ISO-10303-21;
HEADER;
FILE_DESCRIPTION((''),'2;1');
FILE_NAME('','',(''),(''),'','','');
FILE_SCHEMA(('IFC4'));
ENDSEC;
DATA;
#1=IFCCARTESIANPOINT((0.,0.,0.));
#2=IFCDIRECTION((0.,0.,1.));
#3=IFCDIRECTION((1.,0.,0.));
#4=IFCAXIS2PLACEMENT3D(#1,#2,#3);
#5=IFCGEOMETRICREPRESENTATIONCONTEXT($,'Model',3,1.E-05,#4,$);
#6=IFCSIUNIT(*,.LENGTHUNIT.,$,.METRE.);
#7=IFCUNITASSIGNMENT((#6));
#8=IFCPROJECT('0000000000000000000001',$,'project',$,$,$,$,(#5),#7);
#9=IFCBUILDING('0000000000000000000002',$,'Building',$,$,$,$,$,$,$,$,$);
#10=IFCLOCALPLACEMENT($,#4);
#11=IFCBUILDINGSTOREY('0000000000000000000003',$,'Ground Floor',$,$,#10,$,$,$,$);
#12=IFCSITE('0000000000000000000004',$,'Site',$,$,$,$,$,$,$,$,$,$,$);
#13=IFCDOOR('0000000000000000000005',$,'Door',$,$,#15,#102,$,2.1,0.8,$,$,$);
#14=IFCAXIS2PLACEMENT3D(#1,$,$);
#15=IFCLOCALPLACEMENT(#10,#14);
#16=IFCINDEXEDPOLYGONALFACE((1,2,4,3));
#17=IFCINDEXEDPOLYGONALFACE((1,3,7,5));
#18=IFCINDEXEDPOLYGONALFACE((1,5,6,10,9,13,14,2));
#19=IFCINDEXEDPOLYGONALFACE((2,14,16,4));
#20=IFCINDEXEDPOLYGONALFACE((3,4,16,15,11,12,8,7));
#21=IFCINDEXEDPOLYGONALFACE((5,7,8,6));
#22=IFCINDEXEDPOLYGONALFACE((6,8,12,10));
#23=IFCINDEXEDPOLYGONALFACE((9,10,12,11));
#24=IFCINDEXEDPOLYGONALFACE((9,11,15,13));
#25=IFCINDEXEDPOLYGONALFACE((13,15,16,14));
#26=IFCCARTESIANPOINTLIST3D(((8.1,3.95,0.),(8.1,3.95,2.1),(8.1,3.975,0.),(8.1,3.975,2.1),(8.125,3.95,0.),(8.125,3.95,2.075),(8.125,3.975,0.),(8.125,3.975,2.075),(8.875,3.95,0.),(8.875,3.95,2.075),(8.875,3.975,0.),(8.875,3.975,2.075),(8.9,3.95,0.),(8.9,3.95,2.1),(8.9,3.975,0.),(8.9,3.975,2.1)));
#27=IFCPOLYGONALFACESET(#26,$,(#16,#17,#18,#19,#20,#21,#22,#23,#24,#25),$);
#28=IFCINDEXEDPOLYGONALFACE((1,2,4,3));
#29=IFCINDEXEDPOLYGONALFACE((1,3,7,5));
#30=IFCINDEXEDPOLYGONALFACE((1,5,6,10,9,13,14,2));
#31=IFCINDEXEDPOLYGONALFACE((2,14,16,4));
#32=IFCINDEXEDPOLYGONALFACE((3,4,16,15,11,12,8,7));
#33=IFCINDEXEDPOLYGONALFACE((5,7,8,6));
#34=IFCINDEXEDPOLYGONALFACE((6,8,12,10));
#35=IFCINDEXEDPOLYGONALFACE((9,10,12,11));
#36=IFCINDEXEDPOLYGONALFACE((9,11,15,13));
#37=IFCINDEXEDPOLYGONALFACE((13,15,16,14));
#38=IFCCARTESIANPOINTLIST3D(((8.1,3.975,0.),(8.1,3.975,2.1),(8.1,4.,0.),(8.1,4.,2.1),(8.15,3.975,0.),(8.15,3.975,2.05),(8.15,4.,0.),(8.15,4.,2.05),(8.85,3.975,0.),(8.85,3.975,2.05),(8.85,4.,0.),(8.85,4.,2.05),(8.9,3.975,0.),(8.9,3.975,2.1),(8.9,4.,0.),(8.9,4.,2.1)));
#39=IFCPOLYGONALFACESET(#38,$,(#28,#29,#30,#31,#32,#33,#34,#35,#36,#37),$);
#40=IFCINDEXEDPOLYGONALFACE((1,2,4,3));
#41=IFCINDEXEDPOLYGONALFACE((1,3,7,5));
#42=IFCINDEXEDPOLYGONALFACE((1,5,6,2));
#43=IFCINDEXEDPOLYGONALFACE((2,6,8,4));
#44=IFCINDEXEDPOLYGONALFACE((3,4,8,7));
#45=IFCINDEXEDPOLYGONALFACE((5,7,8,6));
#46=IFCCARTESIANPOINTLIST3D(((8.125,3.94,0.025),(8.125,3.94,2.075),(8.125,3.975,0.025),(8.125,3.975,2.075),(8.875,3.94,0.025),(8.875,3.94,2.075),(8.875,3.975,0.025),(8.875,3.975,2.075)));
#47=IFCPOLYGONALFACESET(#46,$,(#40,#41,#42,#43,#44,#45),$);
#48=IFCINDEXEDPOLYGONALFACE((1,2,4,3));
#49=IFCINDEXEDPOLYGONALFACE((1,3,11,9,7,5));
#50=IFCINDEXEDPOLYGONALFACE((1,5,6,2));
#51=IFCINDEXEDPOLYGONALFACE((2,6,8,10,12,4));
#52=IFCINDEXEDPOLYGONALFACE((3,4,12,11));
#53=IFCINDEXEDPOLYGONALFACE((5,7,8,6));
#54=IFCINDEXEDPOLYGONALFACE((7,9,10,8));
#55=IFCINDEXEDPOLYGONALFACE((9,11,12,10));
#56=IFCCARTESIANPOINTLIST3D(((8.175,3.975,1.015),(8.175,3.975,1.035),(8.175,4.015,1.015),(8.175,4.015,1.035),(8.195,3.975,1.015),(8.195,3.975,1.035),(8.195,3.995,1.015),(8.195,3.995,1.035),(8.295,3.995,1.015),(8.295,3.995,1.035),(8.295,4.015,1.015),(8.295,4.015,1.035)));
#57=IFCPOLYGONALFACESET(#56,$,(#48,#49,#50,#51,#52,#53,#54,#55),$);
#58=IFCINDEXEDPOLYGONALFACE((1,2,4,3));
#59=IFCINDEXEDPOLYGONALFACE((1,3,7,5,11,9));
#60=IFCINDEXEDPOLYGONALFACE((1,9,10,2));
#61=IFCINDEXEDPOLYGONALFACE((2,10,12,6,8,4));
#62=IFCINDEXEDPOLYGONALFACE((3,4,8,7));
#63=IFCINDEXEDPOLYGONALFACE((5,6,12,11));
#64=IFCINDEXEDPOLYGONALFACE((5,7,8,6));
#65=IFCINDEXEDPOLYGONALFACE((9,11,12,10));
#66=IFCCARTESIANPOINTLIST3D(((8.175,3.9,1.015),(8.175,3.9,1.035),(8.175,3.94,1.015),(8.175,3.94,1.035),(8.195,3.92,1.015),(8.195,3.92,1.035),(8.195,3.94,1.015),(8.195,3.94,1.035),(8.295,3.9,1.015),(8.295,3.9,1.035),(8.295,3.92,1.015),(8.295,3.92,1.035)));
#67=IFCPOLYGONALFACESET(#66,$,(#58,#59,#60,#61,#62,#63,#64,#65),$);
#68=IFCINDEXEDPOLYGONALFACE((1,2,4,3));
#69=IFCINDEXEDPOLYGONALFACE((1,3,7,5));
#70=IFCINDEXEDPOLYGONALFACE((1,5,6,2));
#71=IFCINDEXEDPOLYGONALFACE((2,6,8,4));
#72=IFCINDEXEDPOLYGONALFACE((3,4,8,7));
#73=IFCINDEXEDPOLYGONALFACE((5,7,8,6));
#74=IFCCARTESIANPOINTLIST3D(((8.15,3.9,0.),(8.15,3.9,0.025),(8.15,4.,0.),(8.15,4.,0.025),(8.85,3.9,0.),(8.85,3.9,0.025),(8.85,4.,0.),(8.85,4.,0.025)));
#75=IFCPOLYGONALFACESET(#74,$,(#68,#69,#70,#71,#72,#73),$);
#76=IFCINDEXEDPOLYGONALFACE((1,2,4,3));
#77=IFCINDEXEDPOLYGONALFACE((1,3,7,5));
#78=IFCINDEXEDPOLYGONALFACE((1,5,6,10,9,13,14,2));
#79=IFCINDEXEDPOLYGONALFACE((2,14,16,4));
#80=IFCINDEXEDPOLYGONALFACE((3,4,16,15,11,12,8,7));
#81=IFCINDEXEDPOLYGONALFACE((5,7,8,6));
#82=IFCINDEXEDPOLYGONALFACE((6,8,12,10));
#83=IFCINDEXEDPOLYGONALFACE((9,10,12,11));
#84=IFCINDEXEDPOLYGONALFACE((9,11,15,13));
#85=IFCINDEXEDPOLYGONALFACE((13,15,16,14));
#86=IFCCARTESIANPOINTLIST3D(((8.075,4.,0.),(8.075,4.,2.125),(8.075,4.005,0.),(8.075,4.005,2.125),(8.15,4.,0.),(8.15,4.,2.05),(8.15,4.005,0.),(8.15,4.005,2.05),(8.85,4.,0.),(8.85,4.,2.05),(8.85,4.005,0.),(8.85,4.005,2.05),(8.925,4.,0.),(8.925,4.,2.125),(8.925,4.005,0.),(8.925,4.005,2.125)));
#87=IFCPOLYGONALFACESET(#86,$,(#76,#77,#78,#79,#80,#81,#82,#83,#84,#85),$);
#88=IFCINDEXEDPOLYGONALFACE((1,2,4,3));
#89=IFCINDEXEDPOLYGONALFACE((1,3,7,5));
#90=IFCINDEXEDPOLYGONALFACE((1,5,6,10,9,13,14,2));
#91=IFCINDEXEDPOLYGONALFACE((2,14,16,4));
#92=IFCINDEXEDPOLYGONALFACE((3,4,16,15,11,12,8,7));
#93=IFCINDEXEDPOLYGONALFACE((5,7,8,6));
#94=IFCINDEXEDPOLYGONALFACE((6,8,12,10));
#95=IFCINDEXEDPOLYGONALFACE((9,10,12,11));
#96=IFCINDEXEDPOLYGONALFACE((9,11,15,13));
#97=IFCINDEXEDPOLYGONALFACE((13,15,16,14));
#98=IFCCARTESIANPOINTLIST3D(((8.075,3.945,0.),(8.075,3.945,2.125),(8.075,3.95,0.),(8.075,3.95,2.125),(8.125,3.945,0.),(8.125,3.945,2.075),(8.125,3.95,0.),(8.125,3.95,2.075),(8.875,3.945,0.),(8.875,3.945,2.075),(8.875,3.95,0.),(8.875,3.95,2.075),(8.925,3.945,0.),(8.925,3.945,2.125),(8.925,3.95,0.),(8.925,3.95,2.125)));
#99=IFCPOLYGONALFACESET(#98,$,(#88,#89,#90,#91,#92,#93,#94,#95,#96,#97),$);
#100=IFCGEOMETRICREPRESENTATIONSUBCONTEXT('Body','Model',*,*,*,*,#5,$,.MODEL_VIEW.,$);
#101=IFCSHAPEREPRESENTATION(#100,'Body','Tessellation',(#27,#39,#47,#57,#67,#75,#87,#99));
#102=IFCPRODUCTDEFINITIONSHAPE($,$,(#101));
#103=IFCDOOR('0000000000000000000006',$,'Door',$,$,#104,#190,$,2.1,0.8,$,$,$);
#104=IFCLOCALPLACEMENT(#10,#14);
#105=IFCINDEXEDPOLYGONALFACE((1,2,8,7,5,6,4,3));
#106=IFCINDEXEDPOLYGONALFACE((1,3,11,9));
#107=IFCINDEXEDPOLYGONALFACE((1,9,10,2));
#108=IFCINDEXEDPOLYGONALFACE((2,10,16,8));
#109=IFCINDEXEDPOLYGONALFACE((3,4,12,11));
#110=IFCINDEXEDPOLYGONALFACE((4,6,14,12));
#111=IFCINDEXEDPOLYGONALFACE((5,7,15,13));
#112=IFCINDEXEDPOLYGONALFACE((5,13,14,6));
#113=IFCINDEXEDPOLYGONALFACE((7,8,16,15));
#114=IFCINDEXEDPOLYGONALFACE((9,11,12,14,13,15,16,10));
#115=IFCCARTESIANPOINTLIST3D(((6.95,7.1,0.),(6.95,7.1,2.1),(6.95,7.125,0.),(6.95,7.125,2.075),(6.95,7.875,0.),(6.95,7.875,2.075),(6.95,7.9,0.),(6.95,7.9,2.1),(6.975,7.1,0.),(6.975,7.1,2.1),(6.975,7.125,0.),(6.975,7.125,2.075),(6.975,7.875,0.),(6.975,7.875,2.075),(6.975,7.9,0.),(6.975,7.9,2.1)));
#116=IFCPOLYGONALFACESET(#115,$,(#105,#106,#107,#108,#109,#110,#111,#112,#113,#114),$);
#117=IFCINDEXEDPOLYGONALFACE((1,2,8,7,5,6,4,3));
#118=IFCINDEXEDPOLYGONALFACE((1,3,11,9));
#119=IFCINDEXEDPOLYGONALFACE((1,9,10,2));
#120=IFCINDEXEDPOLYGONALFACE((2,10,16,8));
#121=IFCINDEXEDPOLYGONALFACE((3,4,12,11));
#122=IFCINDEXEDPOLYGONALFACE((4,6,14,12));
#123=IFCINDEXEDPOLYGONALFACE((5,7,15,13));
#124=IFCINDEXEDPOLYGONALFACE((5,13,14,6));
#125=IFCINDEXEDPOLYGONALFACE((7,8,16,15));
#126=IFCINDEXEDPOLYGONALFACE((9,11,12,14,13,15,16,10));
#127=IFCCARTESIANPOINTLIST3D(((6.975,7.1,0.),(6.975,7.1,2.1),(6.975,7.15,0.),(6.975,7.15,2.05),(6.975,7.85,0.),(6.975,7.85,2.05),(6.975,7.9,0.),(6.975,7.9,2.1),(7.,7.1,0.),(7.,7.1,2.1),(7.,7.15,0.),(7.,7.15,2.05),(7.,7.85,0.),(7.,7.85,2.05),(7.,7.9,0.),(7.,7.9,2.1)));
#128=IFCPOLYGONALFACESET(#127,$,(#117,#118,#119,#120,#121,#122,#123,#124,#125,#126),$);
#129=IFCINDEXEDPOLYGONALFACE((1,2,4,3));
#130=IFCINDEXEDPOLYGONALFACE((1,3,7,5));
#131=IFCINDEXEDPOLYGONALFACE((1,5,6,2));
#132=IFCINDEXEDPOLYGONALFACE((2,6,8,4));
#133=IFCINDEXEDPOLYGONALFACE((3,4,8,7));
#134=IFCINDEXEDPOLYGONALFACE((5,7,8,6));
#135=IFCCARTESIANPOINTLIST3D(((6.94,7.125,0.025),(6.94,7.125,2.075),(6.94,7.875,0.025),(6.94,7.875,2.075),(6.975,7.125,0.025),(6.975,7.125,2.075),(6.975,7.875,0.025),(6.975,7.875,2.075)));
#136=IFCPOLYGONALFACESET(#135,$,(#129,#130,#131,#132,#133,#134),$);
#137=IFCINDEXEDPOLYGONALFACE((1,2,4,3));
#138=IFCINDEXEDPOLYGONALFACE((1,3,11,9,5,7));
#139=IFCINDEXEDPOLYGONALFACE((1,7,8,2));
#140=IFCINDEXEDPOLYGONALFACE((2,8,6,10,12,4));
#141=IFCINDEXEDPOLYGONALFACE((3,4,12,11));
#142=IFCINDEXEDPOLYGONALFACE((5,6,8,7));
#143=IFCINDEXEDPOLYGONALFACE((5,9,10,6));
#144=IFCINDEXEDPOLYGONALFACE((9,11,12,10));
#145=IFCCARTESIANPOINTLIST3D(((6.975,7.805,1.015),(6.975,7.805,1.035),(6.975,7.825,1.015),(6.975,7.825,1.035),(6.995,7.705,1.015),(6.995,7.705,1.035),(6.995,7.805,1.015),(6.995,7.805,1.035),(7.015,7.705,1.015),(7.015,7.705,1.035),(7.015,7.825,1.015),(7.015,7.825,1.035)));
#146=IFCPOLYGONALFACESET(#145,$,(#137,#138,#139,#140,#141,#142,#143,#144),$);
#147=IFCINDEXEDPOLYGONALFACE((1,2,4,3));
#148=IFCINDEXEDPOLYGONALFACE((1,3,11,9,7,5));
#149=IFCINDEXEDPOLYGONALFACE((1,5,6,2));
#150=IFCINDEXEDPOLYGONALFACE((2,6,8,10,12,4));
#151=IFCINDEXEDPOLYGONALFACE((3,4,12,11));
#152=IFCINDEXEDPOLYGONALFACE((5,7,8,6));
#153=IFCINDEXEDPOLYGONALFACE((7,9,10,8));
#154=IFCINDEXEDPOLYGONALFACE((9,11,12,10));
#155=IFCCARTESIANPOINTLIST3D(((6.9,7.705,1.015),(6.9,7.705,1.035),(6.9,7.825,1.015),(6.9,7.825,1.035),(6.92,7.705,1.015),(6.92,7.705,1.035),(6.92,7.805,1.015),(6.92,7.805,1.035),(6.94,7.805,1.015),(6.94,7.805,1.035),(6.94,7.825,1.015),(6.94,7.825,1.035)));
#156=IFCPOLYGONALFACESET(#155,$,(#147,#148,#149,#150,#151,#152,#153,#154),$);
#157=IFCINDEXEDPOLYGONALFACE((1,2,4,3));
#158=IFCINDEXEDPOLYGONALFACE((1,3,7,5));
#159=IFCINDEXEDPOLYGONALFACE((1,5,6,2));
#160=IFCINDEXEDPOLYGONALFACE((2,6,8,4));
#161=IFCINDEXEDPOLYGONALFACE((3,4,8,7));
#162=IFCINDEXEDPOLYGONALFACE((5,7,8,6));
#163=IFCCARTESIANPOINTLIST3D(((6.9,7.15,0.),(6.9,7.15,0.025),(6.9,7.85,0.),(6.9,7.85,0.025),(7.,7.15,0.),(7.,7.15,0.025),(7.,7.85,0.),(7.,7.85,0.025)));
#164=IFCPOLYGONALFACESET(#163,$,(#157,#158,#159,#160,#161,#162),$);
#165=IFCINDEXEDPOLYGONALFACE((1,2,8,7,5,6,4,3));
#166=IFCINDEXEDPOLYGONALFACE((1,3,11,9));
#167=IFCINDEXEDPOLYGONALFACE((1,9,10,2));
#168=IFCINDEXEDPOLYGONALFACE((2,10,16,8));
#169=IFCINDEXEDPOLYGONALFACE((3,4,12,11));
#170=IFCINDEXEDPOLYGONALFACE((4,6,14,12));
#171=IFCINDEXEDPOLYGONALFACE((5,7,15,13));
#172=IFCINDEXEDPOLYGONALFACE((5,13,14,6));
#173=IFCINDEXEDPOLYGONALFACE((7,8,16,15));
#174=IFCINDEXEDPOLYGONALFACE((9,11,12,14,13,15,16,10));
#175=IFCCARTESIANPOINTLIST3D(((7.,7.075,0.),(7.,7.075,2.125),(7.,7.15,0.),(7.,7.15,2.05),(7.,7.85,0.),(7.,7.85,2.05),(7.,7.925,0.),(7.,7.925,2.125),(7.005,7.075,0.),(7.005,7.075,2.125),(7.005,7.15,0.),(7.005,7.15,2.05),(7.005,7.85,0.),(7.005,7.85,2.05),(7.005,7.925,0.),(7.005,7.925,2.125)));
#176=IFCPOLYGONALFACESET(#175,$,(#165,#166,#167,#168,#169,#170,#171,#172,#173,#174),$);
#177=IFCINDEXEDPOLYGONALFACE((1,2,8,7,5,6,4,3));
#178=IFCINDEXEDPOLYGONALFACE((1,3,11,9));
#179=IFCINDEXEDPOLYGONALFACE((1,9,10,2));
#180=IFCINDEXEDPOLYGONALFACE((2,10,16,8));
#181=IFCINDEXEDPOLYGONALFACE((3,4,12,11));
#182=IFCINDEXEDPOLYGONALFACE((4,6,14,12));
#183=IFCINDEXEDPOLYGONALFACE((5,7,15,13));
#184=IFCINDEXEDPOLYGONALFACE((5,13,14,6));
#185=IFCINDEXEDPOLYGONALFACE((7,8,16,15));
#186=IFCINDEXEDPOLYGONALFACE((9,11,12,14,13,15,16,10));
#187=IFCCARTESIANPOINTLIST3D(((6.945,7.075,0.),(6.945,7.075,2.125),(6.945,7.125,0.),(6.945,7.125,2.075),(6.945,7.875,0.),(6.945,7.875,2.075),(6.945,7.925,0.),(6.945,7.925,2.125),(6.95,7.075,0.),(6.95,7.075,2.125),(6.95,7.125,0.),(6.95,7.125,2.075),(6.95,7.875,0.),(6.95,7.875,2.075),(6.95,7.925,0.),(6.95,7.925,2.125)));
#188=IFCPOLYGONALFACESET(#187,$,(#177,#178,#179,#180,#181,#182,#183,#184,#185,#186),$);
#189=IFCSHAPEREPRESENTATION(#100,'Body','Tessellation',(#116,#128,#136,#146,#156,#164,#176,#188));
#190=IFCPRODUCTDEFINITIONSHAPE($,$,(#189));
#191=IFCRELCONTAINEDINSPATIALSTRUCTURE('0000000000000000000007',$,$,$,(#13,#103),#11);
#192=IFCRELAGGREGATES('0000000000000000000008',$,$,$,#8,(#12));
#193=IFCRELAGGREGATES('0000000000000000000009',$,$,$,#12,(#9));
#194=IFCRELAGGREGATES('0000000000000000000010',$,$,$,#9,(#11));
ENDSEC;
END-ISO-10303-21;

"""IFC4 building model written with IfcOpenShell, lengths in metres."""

from ifc_helpers import new_model, si_unit, frame, origin_with_axes, place, context, subcontext, project, spatial, line, indexed_curve, outline, extrude, element, save


model = new_model("IFC4")

# Units and contexts
model_context = context("Model", 3, precision=1e-05, world=origin_with_axes())
body_context = subcontext(model_context, "Body", "Model", "MODEL_VIEW")
ifc_project = project(units=[si_unit("LENGTHUNIT", "METRE")], contexts=[model_context])

# Site, building, storey
site = spatial("IfcSite", under=ifc_project, Name="Site")
building = spatial("IfcBuilding", under=site, Name="Building")
storey_placement = place(None, origin_with_axes())
storey = spatial("IfcBuildingStorey", under=building, at=storey_placement, Name="Ground Floor")

# Doors
door_1_placement = place(storey_placement, frame((8.9, 4.0, 0.0), z_axis=(0.0, 0.0, 1.0), x_axis=(-1.0, 0.0, 0.0)))
element("IfcDoor", 1, at=door_1_placement, inside=storey, Name="Door", OverallHeight=2.1, OverallWidth=0.8, context=body_context, shape_type="SweptSolid", body=[
    extrude(outline(indexed_curve([(0.0, 0.0), (0.0, 2.1), (0.8, 2.1), (0.8, 0.0), (0.775, 0.0), (0.775, 2.075), (0.025, 2.075), (0.025, 0.0)], segments=[line(1, 2, 3, 4, 5, 6, 7, 8, 1)])), frame((0.0, 0.025, 0.0), z_axis=(0.0, -1.0, 0.0), x_axis=(1.0, 0.0, 0.0)), (0.0, 0.0, -1.0), 0.025),
    extrude(outline(indexed_curve([(0.0, 0.0), (0.0, 2.1), (0.8, 2.1), (0.8, 0.0), (0.75, 0.0), (0.75, 2.05), (0.05, 2.05), (0.05, 0.0)], segments=[line(1, 2, 3, 4, 5, 6, 7, 8, 1)])), frame((0.0, 0.0, 0.0), z_axis=(0.0, -1.0, 0.0), x_axis=(1.0, 0.0, 0.0)), (0.0, 0.0, -1.0), 0.025),
    extrude(outline(indexed_curve([(0.0, 0.0), (0.75, 0.0), (0.75, 0.035), (0.0, 0.035)], segments=[line(1, 2, 3, 4, 1)])), frame((0.025, 0.025, 0.025), z_axis=(0.0, 0.0, 1.0), x_axis=(1.0, 0.0, 0.0)), (0.0, 0.0, 1.0), 2.05),
    extrude(outline(indexed_curve([(0.0, 0.0), (0.0, -0.04), (-0.12, -0.04), (-0.12, -0.02), (-0.02, -0.02), (-0.02, 0.0)], segments=[line(1, 2, 3, 4, 5, 6, 1)])), frame((0.725, 0.025, 1.015), z_axis=(0.0, 0.0, 1.0), x_axis=(1.0, 0.0, 0.0)), (0.0, 0.0, 1.0), 0.02),
    extrude(outline(indexed_curve([(0.0, 0.0), (0.0, 0.04), (-0.12, 0.04), (-0.12, 0.02), (-0.02, 0.02), (-0.02, 0.0)], segments=[line(1, 2, 3, 4, 5, 6, 1)])), frame((0.725, 0.06, 1.015), z_axis=(0.0, 0.0, 1.0), x_axis=(1.0, 0.0, 0.0)), (0.0, 0.0, 1.0), 0.02),
    extrude(outline(indexed_curve([(0.0, 0.0), (0.7, 0.0), (0.7, 0.1), (0.0, 0.1)], segments=[line(1, 2, 3, 4, 1)])), frame((0.05, 0.0, 0.0), z_axis=(0.0, 0.0, 1.0), x_axis=(1.0, 0.0, 0.0)), (0.0, 0.0, 1.0), 0.025),
    extrude(outline(indexed_curve([(0.0, 0.0), (0.0, 2.125), (0.85, 2.125), (0.85, 0.0), (0.775, 0.0), (0.775, 2.05), (0.075, 2.05), (0.075, 0.0)], segments=[line(1, 2, 3, 4, 5, 6, 7, 8, 1)])), frame((-0.025, -0.005, 0.0), z_axis=(0.0, -1.0, 0.0), x_axis=(1.0, 0.0, 0.0)), (0.0, 0.0, -1.0), 0.005),
    extrude(outline(indexed_curve([(0.0, 0.0), (0.0, 2.125), (0.85, 2.125), (0.85, 0.0), (0.8, 0.0), (0.8, 2.075), (0.05, 2.075), (0.05, 0.0)], segments=[line(1, 2, 3, 4, 5, 6, 7, 8, 1)])), frame((-0.025, 0.05, 0.0), z_axis=(0.0, -1.0, 0.0), x_axis=(1.0, 0.0, 0.0)), (0.0, 0.0, -1.0), 0.005),
])
door_2_placement = place(storey_placement, frame((7.0, 7.1, 0.0), z_axis=(0.0, 0.0, 1.0), x_axis=(0.0, 1.0, 0.0)))
element("IfcDoor", 2, at=door_2_placement, inside=storey, Name="Door", OverallHeight=2.1, OverallWidth=0.8, context=body_context, shape_type="SweptSolid", body=[
    extrude(outline(indexed_curve([(0.0, 0.0), (0.0, 2.1), (0.8, 2.1), (0.8, 0.0), (0.775, 0.0), (0.775, 2.075), (0.025, 2.075), (0.025, 0.0)], segments=[line(1, 2, 3, 4, 5, 6, 7, 8, 1)])), frame((0.0, 0.025, 0.0), z_axis=(0.0, -1.0, 0.0), x_axis=(1.0, 0.0, 0.0)), (0.0, 0.0, -1.0), 0.025),
    extrude(outline(indexed_curve([(0.0, 0.0), (0.0, 2.1), (0.8, 2.1), (0.8, 0.0), (0.75, 0.0), (0.75, 2.05), (0.05, 2.05), (0.05, 0.0)], segments=[line(1, 2, 3, 4, 5, 6, 7, 8, 1)])), frame((0.0, 0.0, 0.0), z_axis=(0.0, -1.0, 0.0), x_axis=(1.0, 0.0, 0.0)), (0.0, 0.0, -1.0), 0.025),
    extrude(outline(indexed_curve([(0.0, 0.0), (0.75, 0.0), (0.75, 0.035), (0.0, 0.035)], segments=[line(1, 2, 3, 4, 1)])), frame((0.025, 0.025, 0.025), z_axis=(0.0, 0.0, 1.0), x_axis=(1.0, 0.0, 0.0)), (0.0, 0.0, 1.0), 2.05),
    extrude(outline(indexed_curve([(0.0, 0.0), (0.0, -0.04), (-0.12, -0.04), (-0.12, -0.02), (-0.02, -0.02), (-0.02, 0.0)], segments=[line(1, 2, 3, 4, 5, 6, 1)])), frame((0.725, 0.025, 1.015), z_axis=(0.0, 0.0, 1.0), x_axis=(1.0, 0.0, 0.0)), (0.0, 0.0, 1.0), 0.02),
    extrude(outline(indexed_curve([(0.0, 0.0), (0.0, 0.04), (-0.12, 0.04), (-0.12, 0.02), (-0.02, 0.02), (-0.02, 0.0)], segments=[line(1, 2, 3, 4, 5, 6, 1)])), frame((0.725, 0.06, 1.015), z_axis=(0.0, 0.0, 1.0), x_axis=(1.0, 0.0, 0.0)), (0.0, 0.0, 1.0), 0.02),
    extrude(outline(indexed_curve([(0.0, 0.0), (0.7, 0.0), (0.7, 0.1), (0.0, 0.1)], segments=[line(1, 2, 3, 4, 1)])), frame((0.05, 0.0, 0.0), z_axis=(0.0, 0.0, 1.0), x_axis=(1.0, 0.0, 0.0)), (0.0, 0.0, 1.0), 0.025),
    extrude(outline(indexed_curve([(0.0, 0.0), (0.0, 2.125), (0.85, 2.125), (0.85, 0.0), (0.775, 0.0), (0.775, 2.05), (0.075, 2.05), (0.075, 0.0)], segments=[line(1, 2, 3, 4, 5, 6, 7, 8, 1)])), frame((-0.025, -0.005, 0.0), z_axis=(0.0, -1.0, 0.0), x_axis=(1.0, 0.0, 0.0)), (0.0, 0.0, -1.0), 0.005),
    extrude(outline(indexed_curve([(0.0, 0.0), (0.0, 2.125), (0.85, 2.125), (0.85, 0.0), (0.8, 0.0), (0.8, 2.075), (0.05, 2.075), (0.05, 0.0)], segments=[line(1, 2, 3, 4, 5, 6, 7, 8, 1)])), frame((-0.025, 0.05, 0.0), z_axis=(0.0, -1.0, 0.0), x_axis=(1.0, 0.0, 0.0)), (0.0, 0.0, -1.0), 0.005),
])

save(model, "model.ifc")
